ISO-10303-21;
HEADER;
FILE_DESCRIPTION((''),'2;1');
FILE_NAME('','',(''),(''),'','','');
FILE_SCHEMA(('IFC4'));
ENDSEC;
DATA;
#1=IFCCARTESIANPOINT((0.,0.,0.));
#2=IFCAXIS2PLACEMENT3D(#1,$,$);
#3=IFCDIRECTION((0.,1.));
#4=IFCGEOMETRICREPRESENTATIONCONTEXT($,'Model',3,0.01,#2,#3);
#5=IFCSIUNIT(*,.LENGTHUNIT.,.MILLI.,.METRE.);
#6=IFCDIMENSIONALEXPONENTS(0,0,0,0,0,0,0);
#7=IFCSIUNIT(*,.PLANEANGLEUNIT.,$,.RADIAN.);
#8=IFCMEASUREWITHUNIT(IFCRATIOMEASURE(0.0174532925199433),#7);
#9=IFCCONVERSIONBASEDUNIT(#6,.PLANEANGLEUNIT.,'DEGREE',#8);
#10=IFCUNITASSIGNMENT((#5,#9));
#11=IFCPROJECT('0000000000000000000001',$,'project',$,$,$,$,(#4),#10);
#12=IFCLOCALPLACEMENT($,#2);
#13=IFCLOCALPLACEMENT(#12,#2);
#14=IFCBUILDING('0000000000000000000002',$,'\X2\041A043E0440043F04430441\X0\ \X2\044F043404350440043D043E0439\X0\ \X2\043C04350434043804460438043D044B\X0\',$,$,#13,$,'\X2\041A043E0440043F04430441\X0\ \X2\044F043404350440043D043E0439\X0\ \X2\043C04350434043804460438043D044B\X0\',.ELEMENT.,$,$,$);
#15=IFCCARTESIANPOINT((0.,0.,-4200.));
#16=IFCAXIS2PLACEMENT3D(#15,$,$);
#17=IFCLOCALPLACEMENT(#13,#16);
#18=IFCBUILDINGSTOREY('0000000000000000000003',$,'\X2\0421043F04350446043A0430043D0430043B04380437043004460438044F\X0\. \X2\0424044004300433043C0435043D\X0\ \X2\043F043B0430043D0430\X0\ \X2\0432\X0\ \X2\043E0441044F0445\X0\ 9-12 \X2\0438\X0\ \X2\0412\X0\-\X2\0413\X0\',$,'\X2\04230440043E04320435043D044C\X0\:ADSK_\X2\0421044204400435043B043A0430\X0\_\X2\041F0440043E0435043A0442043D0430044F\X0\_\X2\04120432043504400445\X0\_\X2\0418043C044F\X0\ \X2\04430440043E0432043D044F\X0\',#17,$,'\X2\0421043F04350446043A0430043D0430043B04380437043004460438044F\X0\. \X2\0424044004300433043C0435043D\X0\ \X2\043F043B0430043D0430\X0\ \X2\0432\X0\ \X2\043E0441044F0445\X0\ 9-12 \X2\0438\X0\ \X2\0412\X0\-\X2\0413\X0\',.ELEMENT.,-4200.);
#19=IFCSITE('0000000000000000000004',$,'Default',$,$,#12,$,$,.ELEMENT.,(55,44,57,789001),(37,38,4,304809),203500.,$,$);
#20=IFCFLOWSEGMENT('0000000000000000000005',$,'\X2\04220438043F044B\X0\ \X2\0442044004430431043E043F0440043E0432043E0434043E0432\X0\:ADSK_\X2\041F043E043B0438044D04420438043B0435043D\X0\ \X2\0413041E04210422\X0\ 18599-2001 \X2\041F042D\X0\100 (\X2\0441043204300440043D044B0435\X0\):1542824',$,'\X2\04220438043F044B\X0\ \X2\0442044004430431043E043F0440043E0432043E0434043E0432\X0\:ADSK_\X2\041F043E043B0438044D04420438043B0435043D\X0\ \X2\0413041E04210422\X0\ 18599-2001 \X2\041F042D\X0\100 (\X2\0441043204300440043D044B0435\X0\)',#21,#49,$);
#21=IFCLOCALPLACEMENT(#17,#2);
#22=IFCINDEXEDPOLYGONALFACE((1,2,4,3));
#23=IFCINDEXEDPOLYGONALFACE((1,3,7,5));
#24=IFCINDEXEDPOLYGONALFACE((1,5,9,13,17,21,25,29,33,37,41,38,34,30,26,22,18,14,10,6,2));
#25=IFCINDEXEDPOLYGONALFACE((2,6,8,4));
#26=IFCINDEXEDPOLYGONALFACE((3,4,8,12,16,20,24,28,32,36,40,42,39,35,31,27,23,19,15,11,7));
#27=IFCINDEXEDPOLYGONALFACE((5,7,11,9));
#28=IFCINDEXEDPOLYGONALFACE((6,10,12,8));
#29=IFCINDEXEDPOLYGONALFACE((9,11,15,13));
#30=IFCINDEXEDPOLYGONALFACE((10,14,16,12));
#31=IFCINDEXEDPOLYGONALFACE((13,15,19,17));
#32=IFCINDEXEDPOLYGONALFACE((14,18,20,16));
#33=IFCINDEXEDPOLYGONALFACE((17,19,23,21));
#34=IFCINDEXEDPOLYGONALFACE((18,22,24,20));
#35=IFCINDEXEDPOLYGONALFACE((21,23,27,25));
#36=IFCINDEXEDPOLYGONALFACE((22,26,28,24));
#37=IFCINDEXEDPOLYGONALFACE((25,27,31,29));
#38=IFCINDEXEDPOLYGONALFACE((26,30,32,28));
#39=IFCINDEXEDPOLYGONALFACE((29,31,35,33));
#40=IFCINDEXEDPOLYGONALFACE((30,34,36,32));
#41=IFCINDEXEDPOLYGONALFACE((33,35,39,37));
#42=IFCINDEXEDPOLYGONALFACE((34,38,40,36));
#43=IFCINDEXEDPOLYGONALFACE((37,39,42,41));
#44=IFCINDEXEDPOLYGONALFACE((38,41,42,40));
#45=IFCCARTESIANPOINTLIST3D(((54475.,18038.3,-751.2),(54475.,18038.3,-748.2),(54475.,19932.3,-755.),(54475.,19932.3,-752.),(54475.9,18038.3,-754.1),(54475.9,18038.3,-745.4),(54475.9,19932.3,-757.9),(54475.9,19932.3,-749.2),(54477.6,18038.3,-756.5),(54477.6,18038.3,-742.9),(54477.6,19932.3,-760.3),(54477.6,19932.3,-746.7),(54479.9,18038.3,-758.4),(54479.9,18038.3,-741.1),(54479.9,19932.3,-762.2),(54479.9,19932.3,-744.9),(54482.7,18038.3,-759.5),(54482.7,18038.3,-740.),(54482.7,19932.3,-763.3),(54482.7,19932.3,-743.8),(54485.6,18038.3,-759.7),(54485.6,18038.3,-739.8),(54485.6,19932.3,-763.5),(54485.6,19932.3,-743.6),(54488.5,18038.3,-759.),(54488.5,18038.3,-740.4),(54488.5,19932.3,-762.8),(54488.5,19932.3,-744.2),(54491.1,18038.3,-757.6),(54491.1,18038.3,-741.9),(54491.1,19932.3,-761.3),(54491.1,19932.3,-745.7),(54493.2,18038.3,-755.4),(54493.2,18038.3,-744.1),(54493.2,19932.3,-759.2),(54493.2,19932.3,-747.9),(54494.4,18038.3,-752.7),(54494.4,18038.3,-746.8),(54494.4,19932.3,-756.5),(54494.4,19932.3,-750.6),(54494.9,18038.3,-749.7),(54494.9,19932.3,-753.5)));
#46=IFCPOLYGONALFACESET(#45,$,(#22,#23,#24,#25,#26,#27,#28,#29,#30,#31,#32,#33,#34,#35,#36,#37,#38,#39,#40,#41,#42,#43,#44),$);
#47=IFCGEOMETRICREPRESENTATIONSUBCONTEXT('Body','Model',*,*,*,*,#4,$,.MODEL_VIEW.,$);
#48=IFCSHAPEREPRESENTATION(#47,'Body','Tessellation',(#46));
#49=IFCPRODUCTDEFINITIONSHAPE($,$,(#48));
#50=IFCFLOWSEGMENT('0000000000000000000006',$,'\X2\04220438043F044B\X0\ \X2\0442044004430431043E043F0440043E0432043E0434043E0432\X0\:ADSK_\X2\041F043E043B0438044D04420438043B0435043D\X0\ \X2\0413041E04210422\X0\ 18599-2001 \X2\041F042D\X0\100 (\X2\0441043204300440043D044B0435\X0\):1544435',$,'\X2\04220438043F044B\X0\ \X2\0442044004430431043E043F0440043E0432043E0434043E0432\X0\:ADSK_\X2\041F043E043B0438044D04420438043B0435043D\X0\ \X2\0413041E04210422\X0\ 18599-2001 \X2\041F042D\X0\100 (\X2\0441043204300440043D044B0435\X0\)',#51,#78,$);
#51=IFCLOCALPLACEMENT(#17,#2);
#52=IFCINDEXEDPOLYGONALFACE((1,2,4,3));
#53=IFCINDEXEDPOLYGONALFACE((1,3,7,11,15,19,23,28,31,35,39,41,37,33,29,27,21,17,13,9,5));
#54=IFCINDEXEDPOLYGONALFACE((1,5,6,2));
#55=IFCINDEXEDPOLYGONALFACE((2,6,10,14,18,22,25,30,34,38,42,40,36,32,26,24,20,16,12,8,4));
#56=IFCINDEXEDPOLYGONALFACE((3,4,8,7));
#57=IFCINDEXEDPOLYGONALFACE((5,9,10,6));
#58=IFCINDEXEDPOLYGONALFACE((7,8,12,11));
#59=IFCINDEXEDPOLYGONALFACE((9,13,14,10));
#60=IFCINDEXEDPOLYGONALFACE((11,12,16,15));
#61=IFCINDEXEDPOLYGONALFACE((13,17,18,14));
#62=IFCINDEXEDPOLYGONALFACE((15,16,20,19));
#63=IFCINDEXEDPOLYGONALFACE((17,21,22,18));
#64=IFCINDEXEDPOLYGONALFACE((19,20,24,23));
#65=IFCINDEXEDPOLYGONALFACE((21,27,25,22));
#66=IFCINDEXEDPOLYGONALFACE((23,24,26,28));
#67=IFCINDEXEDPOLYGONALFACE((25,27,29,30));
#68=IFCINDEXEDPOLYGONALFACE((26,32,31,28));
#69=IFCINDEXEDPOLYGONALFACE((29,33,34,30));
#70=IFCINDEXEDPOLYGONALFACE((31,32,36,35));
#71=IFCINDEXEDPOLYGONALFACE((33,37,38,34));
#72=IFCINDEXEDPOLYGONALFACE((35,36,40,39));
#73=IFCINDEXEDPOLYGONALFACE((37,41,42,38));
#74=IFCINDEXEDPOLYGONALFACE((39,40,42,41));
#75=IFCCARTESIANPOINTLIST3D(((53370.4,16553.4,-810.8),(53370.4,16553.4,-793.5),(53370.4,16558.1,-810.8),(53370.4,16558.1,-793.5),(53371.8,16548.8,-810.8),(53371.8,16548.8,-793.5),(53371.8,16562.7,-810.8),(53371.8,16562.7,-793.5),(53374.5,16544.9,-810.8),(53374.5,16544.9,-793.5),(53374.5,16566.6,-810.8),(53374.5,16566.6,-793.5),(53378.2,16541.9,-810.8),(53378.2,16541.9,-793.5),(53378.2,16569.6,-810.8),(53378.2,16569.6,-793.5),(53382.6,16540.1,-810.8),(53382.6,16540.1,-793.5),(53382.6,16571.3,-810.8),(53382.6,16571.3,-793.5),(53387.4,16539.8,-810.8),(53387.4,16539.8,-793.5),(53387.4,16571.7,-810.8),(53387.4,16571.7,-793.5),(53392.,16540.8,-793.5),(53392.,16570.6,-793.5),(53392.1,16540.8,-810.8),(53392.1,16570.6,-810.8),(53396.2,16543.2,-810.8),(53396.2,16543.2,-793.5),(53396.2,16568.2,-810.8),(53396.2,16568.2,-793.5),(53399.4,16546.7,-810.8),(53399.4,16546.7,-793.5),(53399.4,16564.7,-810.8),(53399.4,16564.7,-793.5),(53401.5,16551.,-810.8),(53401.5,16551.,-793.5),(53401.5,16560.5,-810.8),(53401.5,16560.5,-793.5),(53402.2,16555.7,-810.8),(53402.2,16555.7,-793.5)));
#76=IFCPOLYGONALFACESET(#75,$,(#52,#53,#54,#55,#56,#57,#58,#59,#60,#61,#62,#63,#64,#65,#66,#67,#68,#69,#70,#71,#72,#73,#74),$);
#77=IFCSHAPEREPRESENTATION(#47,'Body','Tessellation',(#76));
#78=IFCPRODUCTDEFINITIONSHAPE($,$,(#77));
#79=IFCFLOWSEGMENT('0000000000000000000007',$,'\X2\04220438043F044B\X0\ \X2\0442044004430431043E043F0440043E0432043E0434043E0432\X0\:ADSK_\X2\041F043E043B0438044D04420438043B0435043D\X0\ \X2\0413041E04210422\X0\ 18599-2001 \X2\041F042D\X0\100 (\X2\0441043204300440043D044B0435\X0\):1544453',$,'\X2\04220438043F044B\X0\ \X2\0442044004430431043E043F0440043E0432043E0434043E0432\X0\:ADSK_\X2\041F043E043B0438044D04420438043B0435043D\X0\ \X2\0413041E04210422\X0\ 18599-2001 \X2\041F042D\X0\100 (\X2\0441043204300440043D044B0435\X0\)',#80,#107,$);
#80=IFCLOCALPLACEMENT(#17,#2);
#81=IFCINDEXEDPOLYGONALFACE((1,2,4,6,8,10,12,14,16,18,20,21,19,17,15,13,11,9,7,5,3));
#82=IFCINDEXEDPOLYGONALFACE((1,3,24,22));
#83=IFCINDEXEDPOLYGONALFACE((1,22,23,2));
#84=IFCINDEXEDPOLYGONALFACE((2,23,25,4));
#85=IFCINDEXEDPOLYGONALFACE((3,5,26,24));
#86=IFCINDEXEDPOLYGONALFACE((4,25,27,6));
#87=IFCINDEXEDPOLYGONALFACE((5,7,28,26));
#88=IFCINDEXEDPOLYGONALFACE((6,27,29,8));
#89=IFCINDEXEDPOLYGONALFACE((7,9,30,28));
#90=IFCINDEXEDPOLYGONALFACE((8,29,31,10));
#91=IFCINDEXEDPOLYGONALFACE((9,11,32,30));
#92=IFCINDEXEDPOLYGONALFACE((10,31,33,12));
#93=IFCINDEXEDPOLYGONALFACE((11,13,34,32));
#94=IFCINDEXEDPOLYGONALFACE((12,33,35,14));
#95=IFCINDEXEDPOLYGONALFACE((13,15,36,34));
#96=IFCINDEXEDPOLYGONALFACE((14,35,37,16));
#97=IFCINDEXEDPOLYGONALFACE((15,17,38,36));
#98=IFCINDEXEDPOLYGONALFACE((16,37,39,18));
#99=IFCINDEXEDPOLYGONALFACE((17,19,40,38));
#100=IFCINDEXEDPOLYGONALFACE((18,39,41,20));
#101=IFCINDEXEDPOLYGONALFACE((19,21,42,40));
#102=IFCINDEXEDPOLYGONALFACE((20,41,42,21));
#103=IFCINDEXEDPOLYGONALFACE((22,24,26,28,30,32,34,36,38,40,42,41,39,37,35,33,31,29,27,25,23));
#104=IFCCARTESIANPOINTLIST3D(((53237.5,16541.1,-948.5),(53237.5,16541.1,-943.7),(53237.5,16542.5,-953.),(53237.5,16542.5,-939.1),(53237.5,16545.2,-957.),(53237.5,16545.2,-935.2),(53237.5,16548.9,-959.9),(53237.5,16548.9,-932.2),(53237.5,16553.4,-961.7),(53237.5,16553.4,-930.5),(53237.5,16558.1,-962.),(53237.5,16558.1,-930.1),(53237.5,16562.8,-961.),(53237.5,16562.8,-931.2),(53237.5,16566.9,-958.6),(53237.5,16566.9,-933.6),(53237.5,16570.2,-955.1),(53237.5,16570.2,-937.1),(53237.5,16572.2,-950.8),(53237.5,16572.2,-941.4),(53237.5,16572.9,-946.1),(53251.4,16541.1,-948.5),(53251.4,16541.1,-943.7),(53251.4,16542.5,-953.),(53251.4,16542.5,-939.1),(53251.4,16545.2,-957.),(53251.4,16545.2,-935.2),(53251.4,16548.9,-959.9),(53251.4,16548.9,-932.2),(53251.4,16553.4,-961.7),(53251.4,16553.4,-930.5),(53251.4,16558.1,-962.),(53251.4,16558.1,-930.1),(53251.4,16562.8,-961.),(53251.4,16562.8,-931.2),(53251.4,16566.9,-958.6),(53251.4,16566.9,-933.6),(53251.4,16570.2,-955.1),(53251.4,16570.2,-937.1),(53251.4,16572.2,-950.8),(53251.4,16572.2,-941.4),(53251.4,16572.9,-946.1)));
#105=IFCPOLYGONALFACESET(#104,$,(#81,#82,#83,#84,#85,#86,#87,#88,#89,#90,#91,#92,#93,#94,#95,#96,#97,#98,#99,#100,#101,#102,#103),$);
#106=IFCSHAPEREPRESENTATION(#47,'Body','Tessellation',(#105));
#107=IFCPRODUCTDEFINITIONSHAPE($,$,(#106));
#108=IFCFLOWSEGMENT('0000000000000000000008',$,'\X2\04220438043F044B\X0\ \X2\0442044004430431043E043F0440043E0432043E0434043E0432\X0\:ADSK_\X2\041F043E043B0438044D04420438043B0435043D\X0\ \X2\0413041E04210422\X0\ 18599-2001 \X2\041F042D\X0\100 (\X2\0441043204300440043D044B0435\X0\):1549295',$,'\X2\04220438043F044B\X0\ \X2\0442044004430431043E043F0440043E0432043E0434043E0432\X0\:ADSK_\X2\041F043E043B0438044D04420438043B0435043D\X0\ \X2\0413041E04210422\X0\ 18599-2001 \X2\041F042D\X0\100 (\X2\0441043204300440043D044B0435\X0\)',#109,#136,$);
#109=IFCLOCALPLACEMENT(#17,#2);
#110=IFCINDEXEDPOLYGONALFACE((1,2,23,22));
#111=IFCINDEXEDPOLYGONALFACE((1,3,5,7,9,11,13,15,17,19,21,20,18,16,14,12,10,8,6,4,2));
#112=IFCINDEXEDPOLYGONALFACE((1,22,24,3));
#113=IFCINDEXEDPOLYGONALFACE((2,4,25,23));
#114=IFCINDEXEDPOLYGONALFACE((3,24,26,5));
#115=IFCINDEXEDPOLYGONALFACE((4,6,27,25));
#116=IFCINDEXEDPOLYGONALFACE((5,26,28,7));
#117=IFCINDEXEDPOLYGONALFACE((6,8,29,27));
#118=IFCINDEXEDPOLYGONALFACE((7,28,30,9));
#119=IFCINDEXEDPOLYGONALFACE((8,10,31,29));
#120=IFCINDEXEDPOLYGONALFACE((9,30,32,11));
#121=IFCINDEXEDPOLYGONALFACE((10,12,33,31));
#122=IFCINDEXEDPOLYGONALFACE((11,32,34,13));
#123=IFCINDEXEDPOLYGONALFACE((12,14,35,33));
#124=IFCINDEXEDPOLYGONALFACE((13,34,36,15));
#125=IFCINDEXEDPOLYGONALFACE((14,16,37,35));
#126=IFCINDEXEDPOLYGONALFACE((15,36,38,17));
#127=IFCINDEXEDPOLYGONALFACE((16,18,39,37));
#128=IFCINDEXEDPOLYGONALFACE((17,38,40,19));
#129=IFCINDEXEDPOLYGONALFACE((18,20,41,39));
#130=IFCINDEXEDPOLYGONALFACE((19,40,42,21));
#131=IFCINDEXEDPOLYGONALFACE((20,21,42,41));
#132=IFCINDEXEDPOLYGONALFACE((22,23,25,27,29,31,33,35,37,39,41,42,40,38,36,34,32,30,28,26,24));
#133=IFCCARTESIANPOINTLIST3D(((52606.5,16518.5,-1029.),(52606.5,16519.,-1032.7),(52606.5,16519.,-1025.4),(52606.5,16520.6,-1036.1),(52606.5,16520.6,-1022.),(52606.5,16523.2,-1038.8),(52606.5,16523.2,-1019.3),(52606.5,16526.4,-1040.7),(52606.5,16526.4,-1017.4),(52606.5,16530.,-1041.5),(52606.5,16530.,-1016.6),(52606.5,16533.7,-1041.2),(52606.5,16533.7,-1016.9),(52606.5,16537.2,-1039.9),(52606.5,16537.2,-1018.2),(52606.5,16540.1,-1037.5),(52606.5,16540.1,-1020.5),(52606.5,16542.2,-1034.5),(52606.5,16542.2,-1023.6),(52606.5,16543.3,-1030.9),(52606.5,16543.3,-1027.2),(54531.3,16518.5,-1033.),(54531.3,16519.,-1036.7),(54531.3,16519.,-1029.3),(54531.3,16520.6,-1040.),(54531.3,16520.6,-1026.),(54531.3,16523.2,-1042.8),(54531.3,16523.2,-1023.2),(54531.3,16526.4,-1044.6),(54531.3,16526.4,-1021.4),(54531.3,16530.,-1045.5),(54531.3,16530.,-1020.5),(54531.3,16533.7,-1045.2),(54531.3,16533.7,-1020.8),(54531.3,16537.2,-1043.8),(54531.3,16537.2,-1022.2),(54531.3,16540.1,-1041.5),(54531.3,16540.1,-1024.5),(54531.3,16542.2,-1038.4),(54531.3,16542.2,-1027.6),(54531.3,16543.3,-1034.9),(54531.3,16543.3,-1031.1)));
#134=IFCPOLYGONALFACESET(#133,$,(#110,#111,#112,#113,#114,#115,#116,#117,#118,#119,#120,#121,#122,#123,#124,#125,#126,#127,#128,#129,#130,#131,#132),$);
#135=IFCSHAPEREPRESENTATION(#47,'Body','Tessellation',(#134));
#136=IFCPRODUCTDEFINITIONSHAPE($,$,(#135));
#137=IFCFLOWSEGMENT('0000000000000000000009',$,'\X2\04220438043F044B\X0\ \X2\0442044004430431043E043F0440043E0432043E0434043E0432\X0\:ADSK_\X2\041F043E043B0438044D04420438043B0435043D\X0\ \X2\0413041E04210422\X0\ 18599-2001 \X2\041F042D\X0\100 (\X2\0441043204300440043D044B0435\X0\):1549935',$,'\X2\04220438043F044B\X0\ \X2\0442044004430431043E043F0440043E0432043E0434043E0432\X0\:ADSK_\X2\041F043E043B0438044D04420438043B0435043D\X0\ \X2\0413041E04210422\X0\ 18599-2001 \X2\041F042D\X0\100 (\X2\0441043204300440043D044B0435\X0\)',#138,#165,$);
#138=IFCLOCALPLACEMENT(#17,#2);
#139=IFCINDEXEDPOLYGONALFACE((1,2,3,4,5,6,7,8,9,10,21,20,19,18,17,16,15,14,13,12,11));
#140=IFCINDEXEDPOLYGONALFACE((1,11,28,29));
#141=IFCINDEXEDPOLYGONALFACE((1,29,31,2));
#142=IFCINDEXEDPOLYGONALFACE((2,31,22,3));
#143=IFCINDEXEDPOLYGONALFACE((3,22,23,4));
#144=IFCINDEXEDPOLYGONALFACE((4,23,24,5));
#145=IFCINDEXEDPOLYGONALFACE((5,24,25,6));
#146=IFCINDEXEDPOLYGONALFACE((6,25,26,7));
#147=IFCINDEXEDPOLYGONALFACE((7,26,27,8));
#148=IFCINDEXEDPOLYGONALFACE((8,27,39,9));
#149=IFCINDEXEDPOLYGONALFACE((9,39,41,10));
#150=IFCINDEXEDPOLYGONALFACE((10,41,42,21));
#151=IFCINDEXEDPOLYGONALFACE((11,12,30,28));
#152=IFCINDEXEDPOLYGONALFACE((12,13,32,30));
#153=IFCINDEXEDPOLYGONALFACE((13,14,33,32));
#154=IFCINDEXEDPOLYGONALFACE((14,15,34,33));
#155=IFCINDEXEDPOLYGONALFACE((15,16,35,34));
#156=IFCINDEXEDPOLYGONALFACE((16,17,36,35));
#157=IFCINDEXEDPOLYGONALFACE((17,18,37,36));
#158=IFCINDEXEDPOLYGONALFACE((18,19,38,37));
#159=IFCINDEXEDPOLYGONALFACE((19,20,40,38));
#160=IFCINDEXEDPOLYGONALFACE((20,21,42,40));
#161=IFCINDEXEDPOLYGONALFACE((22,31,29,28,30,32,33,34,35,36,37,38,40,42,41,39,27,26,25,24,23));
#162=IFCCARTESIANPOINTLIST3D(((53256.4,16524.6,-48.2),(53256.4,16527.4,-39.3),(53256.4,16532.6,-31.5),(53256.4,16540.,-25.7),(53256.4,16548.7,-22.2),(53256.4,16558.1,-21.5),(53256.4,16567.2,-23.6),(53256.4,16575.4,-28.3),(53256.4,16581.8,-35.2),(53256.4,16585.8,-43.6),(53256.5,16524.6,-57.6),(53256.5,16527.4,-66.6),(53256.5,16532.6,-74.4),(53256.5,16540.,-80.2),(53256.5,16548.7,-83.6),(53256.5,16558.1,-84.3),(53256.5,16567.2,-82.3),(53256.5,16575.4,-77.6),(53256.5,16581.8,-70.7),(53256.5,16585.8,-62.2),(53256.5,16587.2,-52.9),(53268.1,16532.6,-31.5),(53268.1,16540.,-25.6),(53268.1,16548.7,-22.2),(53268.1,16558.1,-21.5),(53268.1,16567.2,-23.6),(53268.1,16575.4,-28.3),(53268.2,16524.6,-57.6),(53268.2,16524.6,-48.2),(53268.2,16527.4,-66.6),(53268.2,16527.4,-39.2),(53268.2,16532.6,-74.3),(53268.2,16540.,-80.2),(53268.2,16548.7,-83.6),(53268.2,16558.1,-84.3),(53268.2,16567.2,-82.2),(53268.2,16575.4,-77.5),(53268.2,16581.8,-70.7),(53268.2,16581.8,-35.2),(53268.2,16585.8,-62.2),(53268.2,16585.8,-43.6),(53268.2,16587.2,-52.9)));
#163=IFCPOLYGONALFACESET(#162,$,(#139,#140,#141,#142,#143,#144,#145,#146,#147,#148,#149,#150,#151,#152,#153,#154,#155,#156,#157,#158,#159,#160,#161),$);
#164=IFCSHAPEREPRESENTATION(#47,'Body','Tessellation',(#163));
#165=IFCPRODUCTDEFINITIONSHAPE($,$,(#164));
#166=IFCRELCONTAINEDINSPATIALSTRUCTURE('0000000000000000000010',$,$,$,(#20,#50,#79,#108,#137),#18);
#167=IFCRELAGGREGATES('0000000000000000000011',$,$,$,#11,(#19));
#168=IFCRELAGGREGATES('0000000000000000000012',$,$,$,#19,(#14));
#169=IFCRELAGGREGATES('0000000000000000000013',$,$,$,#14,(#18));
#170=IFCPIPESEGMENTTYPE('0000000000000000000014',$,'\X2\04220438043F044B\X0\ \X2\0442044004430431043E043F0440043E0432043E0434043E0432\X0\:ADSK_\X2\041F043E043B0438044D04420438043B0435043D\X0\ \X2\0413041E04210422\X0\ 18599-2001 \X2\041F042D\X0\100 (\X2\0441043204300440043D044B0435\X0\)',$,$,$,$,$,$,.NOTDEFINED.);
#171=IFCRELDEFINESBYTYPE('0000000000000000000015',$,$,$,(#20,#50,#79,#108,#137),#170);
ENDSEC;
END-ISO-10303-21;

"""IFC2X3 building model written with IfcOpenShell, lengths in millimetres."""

from ifc_helpers import new_model, entity, si_unit, converted_unit, direction, frame, frame_2d, origin, origin_2d_with_axis, place, context, subcontext, project, spatial, circle, extrude, type_object, element, save


model = new_model("IFC2X3")

# Units and contexts
model_context = context("Model", 3, precision=0.01, world=origin(), true_north=direction((0.0, 1.0)))
body_context = subcontext(model_context, "Body", "Model", "MODEL_VIEW")
ifc_project = project(units=[si_unit("LENGTHUNIT", "METRE", prefix="MILLI"), converted_unit("PLANEANGLEUNIT", "DEGREE", entity("IfcRatioMeasure", 0.0174532925199433), si_unit("PLANEANGLEUNIT", "RADIAN"), dimensions=[0, 0, 0, 0, 0, 0, 0])], contexts=[model_context])

# Site, building, storey
site_placement = place(None, frame((0.0, 0.0, 0.0)))
site = spatial("IfcSite", under=ifc_project, at=site_placement, Name="Default", CompositionType="ELEMENT", RefLatitude=(55, 44, 57, 789001), RefLongitude=(37, 38, 4, 304809), RefElevation=203500.0)
building_placement = place(site_placement, origin())
building = spatial("IfcBuilding", under=site, at=building_placement, Name="Корпус ядерной медицины", LongName="Корпус ядерной медицины", CompositionType="ELEMENT")
storey_placement = place(building_placement, frame((0.0, 0.0, -4200.0)))
storey = spatial("IfcBuildingStorey", under=building, at=storey_placement, Name="Спецканализация. Фрагмен плана в осях 9-12 и В-Г", ObjectType="Уровень:ADSK_Стрелка_Проектная_Вверх_Имя уровня", LongName="Спецканализация. Фрагмен плана в осях 9-12 и В-Г", CompositionType="ELEMENT", Elevation=-4200.0)

# Flow segments
pipe_segment_type = type_object("IfcPipeSegmentType", Name="Типы трубопроводов:ADSK_Полиэтилен ГОСТ 18599-2001 ПЭ100 (сварные)", PredefinedType="NOTDEFINED")
flow_segment_1_placement = place(storey_placement, frame((54473.3, 18038.3, -765.1)))
element("IfcFlowSegment", 1, at=flow_segment_1_placement, inside=storey, type_object=pipe_segment_type, Name="Типы трубопроводов:ADSK_Полиэтилен ГОСТ 18599-2001 ПЭ100 (сварные):1542824", ObjectType="Типы трубопроводов:ADSK_Полиэтилен ГОСТ 18599-2001 ПЭ100 (сварные)", context=body_context, shape_type="SweptSolid", body=[
    extrude(circle(Radius=10.0, at=frame_2d((0.0, 0.0), x_axis=(1.0, 0.0))), frame((11.6, 0.0, 15.4), z_axis=(0.0, 0.999998, -0.002), x_axis=(1.0, 0.0, 0.0)), (0.0, 0.0, 1.0), 1894.0),
])
flow_segment_2_placement = place(storey_placement, frame((53368.6, 16538.1, -810.8)))
element("IfcFlowSegment", 2, at=flow_segment_2_placement, inside=storey, type_object=pipe_segment_type, Name="Типы трубопроводов:ADSK_Полиэтилен ГОСТ 18599-2001 ПЭ100 (сварные):1544435", ObjectType="Типы трубопроводов:ADSK_Полиэтилен ГОСТ 18599-2001 ПЭ100 (сварные)", context=body_context, shape_type="SweptSolid", body=[
    extrude(circle(Radius=16.0, at=origin_2d_with_axis()), frame((17.6, 17.6, 0.0), z_axis=(-0.001249, 0.0, 0.999999), x_axis=(0.999999, 0.0, 0.001249)), (0.0, 0.0, 1.0), 17.3),
])
flow_segment_3_placement = place(storey_placement, frame((53237.5, 16539.3, -963.7)))
element("IfcFlowSegment", 3, at=flow_segment_3_placement, inside=storey, type_object=pipe_segment_type, Name="Типы трубопроводов:ADSK_Полиэтилен ГОСТ 18599-2001 ПЭ100 (сварные):1544453", ObjectType="Типы трубопроводов:ADSK_Полиэтилен ГОСТ 18599-2001 ПЭ100 (сварные)", context=body_context, shape_type="SweptSolid", body=[
    extrude(circle(Radius=16.0, at=origin_2d_with_axis()), frame((0.0, 17.6, 17.6), z_axis=(1.0, 0.0, 0.000899), x_axis=(0.0, 1.0, 0.0)), (0.0, 0.0, 1.0), 13.9),
])
flow_segment_4_placement = place(storey_placement, frame((52606.5, 16516.9, -1047.1)))
element("IfcFlowSegment", 4, at=flow_segment_4_placement, inside=storey, type_object=pipe_segment_type, Name="Типы трубопроводов:ADSK_Полиэтилен ГОСТ 18599-2001 ПЭ100 (сварные):1549295", ObjectType="Типы трубопроводов:ADSK_Полиэтилен ГОСТ 18599-2001 ПЭ100 (сварные)", context=body_context, shape_type="SweptSolid", body=[
    extrude(circle(Radius=12.5, at=frame_2d((0.0, 0.0), x_axis=(1.0, 0.0))), frame((1924.8, 14.1, 14.1), z_axis=(-0.999998, 0.0, 0.002059), x_axis=(0.0, -1.0, 0.0)), (0.0, 0.0, 1.0), 1924.8),
])
flow_segment_5_placement = place(storey_placement, frame((53256.4, 16522.6, -86.0)))
element("IfcFlowSegment", 5, at=flow_segment_5_placement, inside=storey, type_object=pipe_segment_type, Name="Типы трубопроводов:ADSK_Полиэтилен ГОСТ 18599-2001 ПЭ100 (сварные):1549935", ObjectType="Типы трубопроводов:ADSK_Полиэтилен ГОСТ 18599-2001 ПЭ100 (сварные)", context=body_context, shape_type="SweptSolid", body=[
    extrude(circle(Radius=31.5, at=origin_2d_with_axis()), frame((0.1, 33.1, 33.1), z_axis=(0.999998, 0.0, 0.001821), x_axis=(0.0, 1.0, 0.0)), (0.0, 0.0, 1.0), 11.7),
])

save(model, "model.ifc")
